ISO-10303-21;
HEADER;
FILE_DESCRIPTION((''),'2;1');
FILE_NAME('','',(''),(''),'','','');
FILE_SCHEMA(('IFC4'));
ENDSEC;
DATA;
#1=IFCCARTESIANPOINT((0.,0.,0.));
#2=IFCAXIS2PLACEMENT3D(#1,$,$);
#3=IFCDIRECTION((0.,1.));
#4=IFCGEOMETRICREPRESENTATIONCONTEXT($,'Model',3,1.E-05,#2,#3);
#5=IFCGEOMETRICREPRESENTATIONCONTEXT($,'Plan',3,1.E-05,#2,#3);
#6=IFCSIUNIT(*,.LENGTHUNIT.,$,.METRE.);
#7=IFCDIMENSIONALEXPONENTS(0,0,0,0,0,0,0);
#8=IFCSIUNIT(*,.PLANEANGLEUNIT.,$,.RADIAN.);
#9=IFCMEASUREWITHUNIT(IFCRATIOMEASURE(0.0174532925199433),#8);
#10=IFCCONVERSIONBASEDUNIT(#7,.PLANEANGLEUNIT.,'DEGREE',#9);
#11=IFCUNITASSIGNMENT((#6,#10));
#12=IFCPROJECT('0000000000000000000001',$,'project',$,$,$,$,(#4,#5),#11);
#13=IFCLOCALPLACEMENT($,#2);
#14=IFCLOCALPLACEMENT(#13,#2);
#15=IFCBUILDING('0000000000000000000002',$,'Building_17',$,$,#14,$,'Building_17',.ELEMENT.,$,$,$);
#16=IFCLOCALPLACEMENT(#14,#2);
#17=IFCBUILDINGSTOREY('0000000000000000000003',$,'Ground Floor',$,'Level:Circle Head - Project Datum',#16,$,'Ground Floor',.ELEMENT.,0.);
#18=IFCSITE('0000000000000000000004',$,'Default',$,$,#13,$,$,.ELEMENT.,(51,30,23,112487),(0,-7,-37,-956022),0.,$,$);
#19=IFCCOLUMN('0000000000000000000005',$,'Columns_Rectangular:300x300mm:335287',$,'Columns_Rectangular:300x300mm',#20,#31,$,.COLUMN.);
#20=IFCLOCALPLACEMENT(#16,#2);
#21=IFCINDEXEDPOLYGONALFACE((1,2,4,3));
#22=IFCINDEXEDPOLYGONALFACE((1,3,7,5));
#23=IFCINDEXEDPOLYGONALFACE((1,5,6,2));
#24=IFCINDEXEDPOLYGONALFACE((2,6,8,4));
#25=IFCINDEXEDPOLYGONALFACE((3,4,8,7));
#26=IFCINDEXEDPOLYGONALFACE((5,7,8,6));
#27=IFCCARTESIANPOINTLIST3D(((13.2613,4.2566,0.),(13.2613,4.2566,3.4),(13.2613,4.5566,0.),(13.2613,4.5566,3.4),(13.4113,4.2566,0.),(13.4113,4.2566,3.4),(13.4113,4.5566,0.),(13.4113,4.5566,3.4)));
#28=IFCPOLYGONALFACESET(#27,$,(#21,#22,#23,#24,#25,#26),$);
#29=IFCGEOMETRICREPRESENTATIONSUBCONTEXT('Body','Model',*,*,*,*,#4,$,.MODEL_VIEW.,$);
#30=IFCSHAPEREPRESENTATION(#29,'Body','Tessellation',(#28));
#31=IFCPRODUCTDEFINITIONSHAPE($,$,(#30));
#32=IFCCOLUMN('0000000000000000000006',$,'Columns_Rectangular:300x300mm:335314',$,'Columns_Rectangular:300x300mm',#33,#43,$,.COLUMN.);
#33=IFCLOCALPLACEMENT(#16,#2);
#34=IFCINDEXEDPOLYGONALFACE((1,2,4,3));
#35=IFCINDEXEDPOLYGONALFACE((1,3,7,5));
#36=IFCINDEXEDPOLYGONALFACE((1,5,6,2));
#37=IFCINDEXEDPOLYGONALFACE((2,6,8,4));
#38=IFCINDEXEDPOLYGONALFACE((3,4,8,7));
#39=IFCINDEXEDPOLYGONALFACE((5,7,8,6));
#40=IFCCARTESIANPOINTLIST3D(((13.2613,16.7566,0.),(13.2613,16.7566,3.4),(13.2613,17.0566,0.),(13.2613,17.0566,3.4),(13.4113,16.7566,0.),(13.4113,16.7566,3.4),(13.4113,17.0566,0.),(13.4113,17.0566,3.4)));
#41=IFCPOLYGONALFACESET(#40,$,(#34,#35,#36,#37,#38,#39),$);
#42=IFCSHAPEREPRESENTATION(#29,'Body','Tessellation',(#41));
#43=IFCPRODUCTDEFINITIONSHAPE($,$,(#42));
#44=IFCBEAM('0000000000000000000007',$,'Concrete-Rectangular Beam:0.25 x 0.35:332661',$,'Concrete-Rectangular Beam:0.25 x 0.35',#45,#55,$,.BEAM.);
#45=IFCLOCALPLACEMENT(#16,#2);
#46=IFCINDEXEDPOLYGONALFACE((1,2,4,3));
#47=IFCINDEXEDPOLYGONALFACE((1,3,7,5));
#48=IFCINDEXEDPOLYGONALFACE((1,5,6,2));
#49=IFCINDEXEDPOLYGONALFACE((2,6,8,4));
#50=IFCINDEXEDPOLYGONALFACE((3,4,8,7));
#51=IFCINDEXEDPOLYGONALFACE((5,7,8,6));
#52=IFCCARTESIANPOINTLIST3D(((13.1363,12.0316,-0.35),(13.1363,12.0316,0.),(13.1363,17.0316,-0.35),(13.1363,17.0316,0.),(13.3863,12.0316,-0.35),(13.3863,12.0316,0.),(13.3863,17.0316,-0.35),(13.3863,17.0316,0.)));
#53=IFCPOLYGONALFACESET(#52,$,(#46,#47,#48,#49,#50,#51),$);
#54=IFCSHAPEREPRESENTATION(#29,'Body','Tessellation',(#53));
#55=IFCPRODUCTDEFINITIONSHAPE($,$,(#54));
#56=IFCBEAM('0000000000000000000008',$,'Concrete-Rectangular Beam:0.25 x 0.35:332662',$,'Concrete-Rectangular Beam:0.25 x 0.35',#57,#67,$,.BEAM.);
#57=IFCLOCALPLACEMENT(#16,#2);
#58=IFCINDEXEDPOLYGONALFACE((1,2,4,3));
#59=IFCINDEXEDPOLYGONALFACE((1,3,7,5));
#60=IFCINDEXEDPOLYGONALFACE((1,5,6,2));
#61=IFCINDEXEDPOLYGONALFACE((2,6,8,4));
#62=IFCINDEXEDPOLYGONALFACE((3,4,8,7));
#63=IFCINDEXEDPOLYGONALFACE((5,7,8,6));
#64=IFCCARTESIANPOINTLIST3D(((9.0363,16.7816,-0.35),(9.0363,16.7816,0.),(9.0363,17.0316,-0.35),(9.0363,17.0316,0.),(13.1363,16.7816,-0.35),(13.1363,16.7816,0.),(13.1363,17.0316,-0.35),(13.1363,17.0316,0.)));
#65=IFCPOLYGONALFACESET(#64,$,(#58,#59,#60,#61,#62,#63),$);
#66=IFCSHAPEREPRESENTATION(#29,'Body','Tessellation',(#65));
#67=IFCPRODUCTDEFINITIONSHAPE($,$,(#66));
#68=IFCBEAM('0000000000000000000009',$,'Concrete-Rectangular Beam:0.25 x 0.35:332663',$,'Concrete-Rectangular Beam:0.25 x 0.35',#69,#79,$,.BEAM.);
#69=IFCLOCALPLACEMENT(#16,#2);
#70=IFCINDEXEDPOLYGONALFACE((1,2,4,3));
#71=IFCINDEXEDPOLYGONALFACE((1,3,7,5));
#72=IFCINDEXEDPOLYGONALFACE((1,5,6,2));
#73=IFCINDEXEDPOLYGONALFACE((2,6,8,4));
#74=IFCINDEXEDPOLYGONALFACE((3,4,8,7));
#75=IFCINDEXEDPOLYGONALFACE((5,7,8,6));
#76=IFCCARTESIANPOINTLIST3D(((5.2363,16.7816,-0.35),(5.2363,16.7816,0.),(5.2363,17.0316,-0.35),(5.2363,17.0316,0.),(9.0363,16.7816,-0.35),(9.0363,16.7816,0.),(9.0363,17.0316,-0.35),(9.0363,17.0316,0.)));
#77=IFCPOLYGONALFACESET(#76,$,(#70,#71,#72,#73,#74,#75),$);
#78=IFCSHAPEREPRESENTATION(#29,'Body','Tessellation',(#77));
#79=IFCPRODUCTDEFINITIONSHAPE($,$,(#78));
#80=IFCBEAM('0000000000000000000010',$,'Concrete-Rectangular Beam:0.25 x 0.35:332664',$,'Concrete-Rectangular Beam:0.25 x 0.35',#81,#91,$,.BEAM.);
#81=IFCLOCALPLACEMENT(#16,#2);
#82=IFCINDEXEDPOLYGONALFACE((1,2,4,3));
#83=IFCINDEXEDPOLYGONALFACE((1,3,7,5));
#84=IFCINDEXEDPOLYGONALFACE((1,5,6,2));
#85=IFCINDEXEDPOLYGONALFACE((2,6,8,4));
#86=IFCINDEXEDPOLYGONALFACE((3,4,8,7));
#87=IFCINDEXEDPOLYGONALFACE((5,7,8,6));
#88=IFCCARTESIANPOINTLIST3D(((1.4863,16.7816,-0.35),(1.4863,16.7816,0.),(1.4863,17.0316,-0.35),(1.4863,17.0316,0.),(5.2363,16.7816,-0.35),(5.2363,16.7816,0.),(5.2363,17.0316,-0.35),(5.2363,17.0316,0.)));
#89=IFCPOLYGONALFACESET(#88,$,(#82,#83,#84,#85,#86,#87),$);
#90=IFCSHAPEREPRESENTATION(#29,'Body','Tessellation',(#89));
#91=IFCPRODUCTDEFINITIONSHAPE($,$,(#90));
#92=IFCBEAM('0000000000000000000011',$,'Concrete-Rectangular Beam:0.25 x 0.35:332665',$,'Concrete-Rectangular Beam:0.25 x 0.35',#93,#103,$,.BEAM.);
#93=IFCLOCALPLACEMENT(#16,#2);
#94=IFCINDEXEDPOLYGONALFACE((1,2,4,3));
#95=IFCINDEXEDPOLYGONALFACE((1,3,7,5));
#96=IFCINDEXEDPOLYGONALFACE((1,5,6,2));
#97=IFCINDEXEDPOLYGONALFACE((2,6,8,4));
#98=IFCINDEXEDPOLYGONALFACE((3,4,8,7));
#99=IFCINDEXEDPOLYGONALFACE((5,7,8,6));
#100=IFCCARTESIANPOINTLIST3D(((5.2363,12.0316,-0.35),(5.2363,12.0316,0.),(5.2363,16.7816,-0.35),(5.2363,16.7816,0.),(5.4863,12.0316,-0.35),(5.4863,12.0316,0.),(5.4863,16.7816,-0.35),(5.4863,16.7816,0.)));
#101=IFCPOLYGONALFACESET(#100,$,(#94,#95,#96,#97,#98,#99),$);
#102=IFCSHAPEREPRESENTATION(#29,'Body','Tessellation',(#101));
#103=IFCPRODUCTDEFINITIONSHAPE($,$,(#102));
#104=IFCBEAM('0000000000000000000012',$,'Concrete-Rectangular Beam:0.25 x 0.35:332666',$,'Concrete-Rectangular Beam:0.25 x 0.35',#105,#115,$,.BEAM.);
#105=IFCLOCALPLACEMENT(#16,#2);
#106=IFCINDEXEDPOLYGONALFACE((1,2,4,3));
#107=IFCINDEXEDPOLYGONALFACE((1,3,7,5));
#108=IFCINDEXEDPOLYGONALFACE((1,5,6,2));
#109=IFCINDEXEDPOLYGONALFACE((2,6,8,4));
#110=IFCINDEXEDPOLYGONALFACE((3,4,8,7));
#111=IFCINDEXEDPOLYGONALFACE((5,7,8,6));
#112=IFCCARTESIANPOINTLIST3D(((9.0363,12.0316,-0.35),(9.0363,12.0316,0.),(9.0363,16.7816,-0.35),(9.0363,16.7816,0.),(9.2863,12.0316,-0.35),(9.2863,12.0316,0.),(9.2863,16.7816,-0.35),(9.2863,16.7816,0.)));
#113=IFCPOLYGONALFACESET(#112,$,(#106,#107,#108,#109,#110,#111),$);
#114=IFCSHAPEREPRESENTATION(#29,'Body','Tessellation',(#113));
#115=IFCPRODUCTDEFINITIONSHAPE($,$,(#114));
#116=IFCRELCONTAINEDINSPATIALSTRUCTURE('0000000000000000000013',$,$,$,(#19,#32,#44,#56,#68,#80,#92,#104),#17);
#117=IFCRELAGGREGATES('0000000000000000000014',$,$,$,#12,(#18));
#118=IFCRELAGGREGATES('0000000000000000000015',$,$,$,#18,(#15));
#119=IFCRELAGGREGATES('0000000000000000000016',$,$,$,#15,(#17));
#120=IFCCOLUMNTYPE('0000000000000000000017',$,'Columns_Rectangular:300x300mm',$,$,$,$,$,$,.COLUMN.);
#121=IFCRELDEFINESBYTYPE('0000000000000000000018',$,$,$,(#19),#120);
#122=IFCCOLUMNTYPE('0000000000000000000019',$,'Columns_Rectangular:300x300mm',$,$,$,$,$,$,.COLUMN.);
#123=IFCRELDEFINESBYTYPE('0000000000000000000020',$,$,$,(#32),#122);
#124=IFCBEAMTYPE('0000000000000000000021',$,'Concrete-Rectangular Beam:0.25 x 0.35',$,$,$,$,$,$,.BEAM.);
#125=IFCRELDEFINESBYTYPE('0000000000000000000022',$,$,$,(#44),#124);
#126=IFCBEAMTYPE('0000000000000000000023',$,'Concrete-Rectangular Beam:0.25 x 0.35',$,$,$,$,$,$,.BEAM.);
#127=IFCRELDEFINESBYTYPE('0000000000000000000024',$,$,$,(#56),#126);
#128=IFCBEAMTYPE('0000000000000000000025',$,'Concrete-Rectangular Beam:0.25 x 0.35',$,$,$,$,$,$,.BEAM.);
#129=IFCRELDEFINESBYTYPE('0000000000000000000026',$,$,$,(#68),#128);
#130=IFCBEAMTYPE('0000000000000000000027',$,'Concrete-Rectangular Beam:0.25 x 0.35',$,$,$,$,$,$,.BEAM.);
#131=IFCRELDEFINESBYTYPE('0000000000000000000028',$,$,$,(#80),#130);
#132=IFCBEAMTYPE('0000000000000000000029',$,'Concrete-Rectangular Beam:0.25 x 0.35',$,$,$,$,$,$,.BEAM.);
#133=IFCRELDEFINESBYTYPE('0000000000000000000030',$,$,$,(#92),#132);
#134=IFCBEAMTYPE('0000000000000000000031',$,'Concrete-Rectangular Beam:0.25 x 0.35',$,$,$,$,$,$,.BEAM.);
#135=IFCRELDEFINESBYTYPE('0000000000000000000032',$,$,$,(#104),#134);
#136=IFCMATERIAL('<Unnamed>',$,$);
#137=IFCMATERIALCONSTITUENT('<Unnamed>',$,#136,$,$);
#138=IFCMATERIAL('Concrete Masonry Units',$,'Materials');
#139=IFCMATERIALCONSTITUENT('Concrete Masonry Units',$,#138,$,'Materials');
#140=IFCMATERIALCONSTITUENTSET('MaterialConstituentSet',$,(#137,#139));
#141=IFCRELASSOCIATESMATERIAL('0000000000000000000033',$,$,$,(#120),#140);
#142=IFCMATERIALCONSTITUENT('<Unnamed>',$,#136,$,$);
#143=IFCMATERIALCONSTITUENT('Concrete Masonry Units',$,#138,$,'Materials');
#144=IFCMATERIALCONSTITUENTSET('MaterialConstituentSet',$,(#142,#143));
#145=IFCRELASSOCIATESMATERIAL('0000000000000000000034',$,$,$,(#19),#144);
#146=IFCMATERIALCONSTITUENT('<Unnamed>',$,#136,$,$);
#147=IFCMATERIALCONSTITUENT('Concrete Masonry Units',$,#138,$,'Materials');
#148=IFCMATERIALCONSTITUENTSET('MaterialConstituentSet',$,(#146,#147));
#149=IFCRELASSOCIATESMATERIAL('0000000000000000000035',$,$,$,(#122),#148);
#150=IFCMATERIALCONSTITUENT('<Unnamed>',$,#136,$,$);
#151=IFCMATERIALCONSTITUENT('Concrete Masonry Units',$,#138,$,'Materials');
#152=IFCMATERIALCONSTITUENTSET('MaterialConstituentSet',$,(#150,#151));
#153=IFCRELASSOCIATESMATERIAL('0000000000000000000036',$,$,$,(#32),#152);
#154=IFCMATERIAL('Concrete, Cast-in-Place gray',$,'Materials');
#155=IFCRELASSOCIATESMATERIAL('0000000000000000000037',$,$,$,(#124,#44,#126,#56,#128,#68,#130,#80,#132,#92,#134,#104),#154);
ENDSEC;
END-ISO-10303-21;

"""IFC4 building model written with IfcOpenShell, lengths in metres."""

from ifc_helpers import new_model, entity, si_unit, converted_unit, direction, frame, origin, place, context, subcontext, project, spatial, indexed_curve, outline, extrude, source, transform, mapped, material, constituent, constituent_set, type_object, type_shapes, element, save


model = new_model("IFC4")

# Units and contexts
model_context = context("Model", 3, precision=1e-05, world=origin(), true_north=direction((0.0, 1.0)))
plan_context = context("Plan", 3, precision=1e-05, world=origin(), true_north=direction((0.0, 1.0)))
body_context = subcontext(model_context, "Body", "Model", "MODEL_VIEW")
ifc_project = project(units=[si_unit("LENGTHUNIT", "METRE"), converted_unit("PLANEANGLEUNIT", "DEGREE", entity("IfcRatioMeasure", 0.0174532925199433), si_unit("PLANEANGLEUNIT", "RADIAN"), dimensions=[0, 0, 0, 0, 0, 0, 0])], contexts=[model_context, plan_context])

# Site, building, storey
site_placement = place(None, origin())
site = spatial("IfcSite", under=ifc_project, at=site_placement, Name="Default", CompositionType="ELEMENT", RefLatitude=(51, 30, 23, 112487), RefLongitude=(0, -7, -37, -956022), RefElevation=0.0)
building_placement = place(site_placement, origin())
building = spatial("IfcBuilding", under=site, at=building_placement, Name="Building_17", LongName="Building_17", CompositionType="ELEMENT")
storey_placement = place(building_placement, origin())
storey = spatial("IfcBuildingStorey", under=building, at=storey_placement, Name="Ground Floor", ObjectType="Level:Circle Head - Project Datum", LongName="Ground Floor", CompositionType="ELEMENT", Elevation=0.0)

# Columns
ifc_material_1 = material(Name="<Unnamed>")
ifc_constituent_1 = constituent(ifc_material_1, Name="<Unnamed>")
ifc_material_2 = material(Name="Concrete Masonry Units", Category="Materials")
ifc_constituent_2 = constituent(ifc_material_2, Name="Concrete Masonry Units", Category="Materials")
ifc_constituent_set_1 = constituent_set(constituents=[ifc_constituent_1, ifc_constituent_2], Name="MaterialConstituentSet")
ifc_constituent_3 = constituent(ifc_material_1, Name="<Unnamed>")
ifc_constituent_4 = constituent(ifc_material_2, Name="Concrete Masonry Units", Category="Materials")
ifc_constituent_set_2 = constituent_set(constituents=[ifc_constituent_3, ifc_constituent_4], Name="MaterialConstituentSet")
column_type_1 = type_object("IfcColumnType", Name="Columns_Rectangular:300x300mm", PredefinedType="COLUMN", material=ifc_constituent_set_2)
shared_shape_1 = source(origin(), body_context, "Body", "SweptSolid", [
    extrude(outline(indexed_curve([(-0.15, -0.075), (0.15, -0.075), (0.15, 0.075), (-0.15, 0.075), (-0.15, -0.075)], self_intersect=False)), frame((13.3363, 4.4066, 0.0), z_axis=(0.0, 0.0, 1.0), x_axis=(0.0, -1.0, 0.0)), (0.0, 0.0, 1.0), 3.4),
])
type_shapes(column_type_1, [shared_shape_1])
column_1_placement = place(storey_placement, origin())
element("IfcColumn", 1, at=column_1_placement, inside=storey, type_object=column_type_1, material=ifc_constituent_set_1, Name="Columns_Rectangular:300x300mm:335287", ObjectType="Columns_Rectangular:300x300mm", PredefinedType="COLUMN", context=body_context, shape_type="MappedRepresentation", body=[
    mapped(shared_shape_1, transform((0.0, 0.0, 0.0), scale=1.0)),
])
ifc_constituent_5 = constituent(ifc_material_1, Name="<Unnamed>")
ifc_constituent_6 = constituent(ifc_material_2, Name="Concrete Masonry Units", Category="Materials")
ifc_constituent_set_3 = constituent_set(constituents=[ifc_constituent_5, ifc_constituent_6], Name="MaterialConstituentSet")
ifc_constituent_7 = constituent(ifc_material_1, Name="<Unnamed>")
ifc_constituent_8 = constituent(ifc_material_2, Name="Concrete Masonry Units", Category="Materials")
ifc_constituent_set_4 = constituent_set(constituents=[ifc_constituent_7, ifc_constituent_8], Name="MaterialConstituentSet")
column_type_2 = type_object("IfcColumnType", Name="Columns_Rectangular:300x300mm", PredefinedType="COLUMN", material=ifc_constituent_set_4)
shared_shape_2 = source(origin(), body_context, "Body", "SweptSolid", [
    extrude(outline(indexed_curve([(-0.15, -0.075), (0.15, -0.075), (0.15, 0.075), (-0.15, 0.075), (-0.15, -0.075)], self_intersect=False)), frame((13.3363, 16.9066, 0.0), z_axis=(0.0, 0.0, 1.0), x_axis=(0.0, -1.0, 0.0)), (0.0, 0.0, 1.0), 3.4),
])
type_shapes(column_type_2, [shared_shape_2])
column_2_placement = place(storey_placement, origin())
element("IfcColumn", 2, at=column_2_placement, inside=storey, type_object=column_type_2, material=ifc_constituent_set_3, Name="Columns_Rectangular:300x300mm:335314", ObjectType="Columns_Rectangular:300x300mm", PredefinedType="COLUMN", context=body_context, shape_type="MappedRepresentation", body=[
    mapped(shared_shape_2, transform((0.0, 0.0, 0.0), scale=1.0)),
])

# Beams
ifc_material_3 = material(Name="Concrete, Cast-in-Place gray", Category="Materials")
beam_type_1 = type_object("IfcBeamType", Name="Concrete-Rectangular Beam:0.25 x 0.35", PredefinedType="BEAM", material=ifc_material_3)
shared_shape_3 = source(origin(), body_context, "Body", "SweptSolid", [
    extrude(outline(indexed_curve([(-0.125, -0.175), (0.125, -0.175), (0.125, 0.175), (-0.125, 0.175), (-0.125, -0.175)], self_intersect=False)), frame((13.2613, 12.0316, -0.175), z_axis=(0.0, 1.0, 0.0), x_axis=(-1.0, 0.0, 0.0)), (0.0, 0.0, 1.0), 5.0),
])
type_shapes(beam_type_1, [shared_shape_3])
beam_1_placement = place(storey_placement, origin())
element("IfcBeam", 3, at=beam_1_placement, inside=storey, type_object=beam_type_1, material=ifc_material_3, Name="Concrete-Rectangular Beam:0.25 x 0.35:332661", ObjectType="Concrete-Rectangular Beam:0.25 x 0.35", PredefinedType="BEAM", context=body_context, shape_type="MappedRepresentation", body=[
    mapped(shared_shape_3, transform((0.0, 0.0, 0.0), scale=1.0)),
])
beam_type_2 = type_object("IfcBeamType", Name="Concrete-Rectangular Beam:0.25 x 0.35", PredefinedType="BEAM", material=ifc_material_3)
shared_shape_4 = source(origin(), body_context, "Body", "SweptSolid", [
    extrude(outline(indexed_curve([(-0.175, -0.125), (0.175, -0.125), (0.175, 0.125), (-0.175, 0.125), (-0.175, -0.125)], self_intersect=False)), frame((13.1363, 16.9066, -0.175), z_axis=(-1.0, 0.0, 0.0), x_axis=(0.0, 0.0, -1.0)), (0.0, 0.0, 1.0), 4.1),
])
type_shapes(beam_type_2, [shared_shape_4])
beam_2_placement = place(storey_placement, origin())
element("IfcBeam", 4, at=beam_2_placement, inside=storey, type_object=beam_type_2, material=ifc_material_3, Name="Concrete-Rectangular Beam:0.25 x 0.35:332662", ObjectType="Concrete-Rectangular Beam:0.25 x 0.35", PredefinedType="BEAM", context=body_context, shape_type="MappedRepresentation", body=[
    mapped(shared_shape_4, transform((0.0, 0.0, 0.0), scale=1.0)),
])
beam_type_3 = type_object("IfcBeamType", Name="Concrete-Rectangular Beam:0.25 x 0.35", PredefinedType="BEAM", material=ifc_material_3)
shared_shape_5 = source(origin(), body_context, "Body", "SweptSolid", [
    extrude(outline(indexed_curve([(-0.175, -0.125), (0.175, -0.125), (0.175, 0.125), (-0.175, 0.125), (-0.175, -0.125)], self_intersect=False)), frame((9.0363, 16.9066, -0.175), z_axis=(-1.0, 0.0, 0.0), x_axis=(0.0, 0.0, -1.0)), (0.0, 0.0, 1.0), 3.8),
])
type_shapes(beam_type_3, [shared_shape_5])
beam_3_placement = place(storey_placement, origin())
element("IfcBeam", 5, at=beam_3_placement, inside=storey, type_object=beam_type_3, material=ifc_material_3, Name="Concrete-Rectangular Beam:0.25 x 0.35:332663", ObjectType="Concrete-Rectangular Beam:0.25 x 0.35", PredefinedType="BEAM", context=body_context, shape_type="MappedRepresentation", body=[
    mapped(shared_shape_5, transform((0.0, 0.0, 0.0), scale=1.0)),
])
beam_type_4 = type_object("IfcBeamType", Name="Concrete-Rectangular Beam:0.25 x 0.35", PredefinedType="BEAM", material=ifc_material_3)
shared_shape_6 = source(origin(), body_context, "Body", "SweptSolid", [
    extrude(outline(indexed_curve([(-0.175, -0.125), (0.175, -0.125), (0.175, 0.125), (-0.175, 0.125), (-0.175, -0.125)], self_intersect=False)), frame((5.2363, 16.9066, -0.175), z_axis=(-1.0, 0.0, 0.0), x_axis=(0.0, 0.0, -1.0)), (0.0, 0.0, 1.0), 3.75),
])
type_shapes(beam_type_4, [shared_shape_6])
beam_4_placement = place(storey_placement, origin())
element("IfcBeam", 6, at=beam_4_placement, inside=storey, type_object=beam_type_4, material=ifc_material_3, Name="Concrete-Rectangular Beam:0.25 x 0.35:332664", ObjectType="Concrete-Rectangular Beam:0.25 x 0.35", PredefinedType="BEAM", context=body_context, shape_type="MappedRepresentation", body=[
    mapped(shared_shape_6, transform((0.0, 0.0, 0.0), scale=1.0)),
])
beam_type_5 = type_object("IfcBeamType", Name="Concrete-Rectangular Beam:0.25 x 0.35", PredefinedType="BEAM", material=ifc_material_3)
shared_shape_7 = source(origin(), body_context, "Body", "SweptSolid", [
    extrude(outline(indexed_curve([(-0.125, -0.175), (0.125, -0.175), (0.125, 0.175), (-0.125, 0.175), (-0.125, -0.175)], self_intersect=False)), frame((5.3613, 16.7816, -0.175), z_axis=(0.0, -1.0, 0.0), x_axis=(-1.0, 0.0, 0.0)), (0.0, 0.0, 1.0), 4.75),
])
type_shapes(beam_type_5, [shared_shape_7])
beam_5_placement = place(storey_placement, origin())
element("IfcBeam", 7, at=beam_5_placement, inside=storey, type_object=beam_type_5, material=ifc_material_3, Name="Concrete-Rectangular Beam:0.25 x 0.35:332665", ObjectType="Concrete-Rectangular Beam:0.25 x 0.35", PredefinedType="BEAM", context=body_context, shape_type="MappedRepresentation", body=[
    mapped(shared_shape_7, transform((0.0, 0.0, 0.0), scale=1.0)),
])
beam_type_6 = type_object("IfcBeamType", Name="Concrete-Rectangular Beam:0.25 x 0.35", PredefinedType="BEAM", material=ifc_material_3)
shared_shape_8 = source(origin(), body_context, "Body", "SweptSolid", [
    extrude(outline(indexed_curve([(-0.125, -0.175), (0.125, -0.175), (0.125, 0.175), (-0.125, 0.175), (-0.125, -0.175)], self_intersect=False)), frame((9.1613, 16.7816, -0.175), z_axis=(0.0, -1.0, 0.0), x_axis=(-1.0, 0.0, 0.0)), (0.0, 0.0, 1.0), 4.75),
])
type_shapes(beam_type_6, [shared_shape_8])
beam_6_placement = place(storey_placement, origin())
element("IfcBeam", 8, at=beam_6_placement, inside=storey, type_object=beam_type_6, material=ifc_material_3, Name="Concrete-Rectangular Beam:0.25 x 0.35:332666", ObjectType="Concrete-Rectangular Beam:0.25 x 0.35", PredefinedType="BEAM", context=body_context, shape_type="MappedRepresentation", body=[
    mapped(shared_shape_8, transform((0.0, 0.0, 0.0), scale=1.0)),
])

save(model, "model.ifc")
